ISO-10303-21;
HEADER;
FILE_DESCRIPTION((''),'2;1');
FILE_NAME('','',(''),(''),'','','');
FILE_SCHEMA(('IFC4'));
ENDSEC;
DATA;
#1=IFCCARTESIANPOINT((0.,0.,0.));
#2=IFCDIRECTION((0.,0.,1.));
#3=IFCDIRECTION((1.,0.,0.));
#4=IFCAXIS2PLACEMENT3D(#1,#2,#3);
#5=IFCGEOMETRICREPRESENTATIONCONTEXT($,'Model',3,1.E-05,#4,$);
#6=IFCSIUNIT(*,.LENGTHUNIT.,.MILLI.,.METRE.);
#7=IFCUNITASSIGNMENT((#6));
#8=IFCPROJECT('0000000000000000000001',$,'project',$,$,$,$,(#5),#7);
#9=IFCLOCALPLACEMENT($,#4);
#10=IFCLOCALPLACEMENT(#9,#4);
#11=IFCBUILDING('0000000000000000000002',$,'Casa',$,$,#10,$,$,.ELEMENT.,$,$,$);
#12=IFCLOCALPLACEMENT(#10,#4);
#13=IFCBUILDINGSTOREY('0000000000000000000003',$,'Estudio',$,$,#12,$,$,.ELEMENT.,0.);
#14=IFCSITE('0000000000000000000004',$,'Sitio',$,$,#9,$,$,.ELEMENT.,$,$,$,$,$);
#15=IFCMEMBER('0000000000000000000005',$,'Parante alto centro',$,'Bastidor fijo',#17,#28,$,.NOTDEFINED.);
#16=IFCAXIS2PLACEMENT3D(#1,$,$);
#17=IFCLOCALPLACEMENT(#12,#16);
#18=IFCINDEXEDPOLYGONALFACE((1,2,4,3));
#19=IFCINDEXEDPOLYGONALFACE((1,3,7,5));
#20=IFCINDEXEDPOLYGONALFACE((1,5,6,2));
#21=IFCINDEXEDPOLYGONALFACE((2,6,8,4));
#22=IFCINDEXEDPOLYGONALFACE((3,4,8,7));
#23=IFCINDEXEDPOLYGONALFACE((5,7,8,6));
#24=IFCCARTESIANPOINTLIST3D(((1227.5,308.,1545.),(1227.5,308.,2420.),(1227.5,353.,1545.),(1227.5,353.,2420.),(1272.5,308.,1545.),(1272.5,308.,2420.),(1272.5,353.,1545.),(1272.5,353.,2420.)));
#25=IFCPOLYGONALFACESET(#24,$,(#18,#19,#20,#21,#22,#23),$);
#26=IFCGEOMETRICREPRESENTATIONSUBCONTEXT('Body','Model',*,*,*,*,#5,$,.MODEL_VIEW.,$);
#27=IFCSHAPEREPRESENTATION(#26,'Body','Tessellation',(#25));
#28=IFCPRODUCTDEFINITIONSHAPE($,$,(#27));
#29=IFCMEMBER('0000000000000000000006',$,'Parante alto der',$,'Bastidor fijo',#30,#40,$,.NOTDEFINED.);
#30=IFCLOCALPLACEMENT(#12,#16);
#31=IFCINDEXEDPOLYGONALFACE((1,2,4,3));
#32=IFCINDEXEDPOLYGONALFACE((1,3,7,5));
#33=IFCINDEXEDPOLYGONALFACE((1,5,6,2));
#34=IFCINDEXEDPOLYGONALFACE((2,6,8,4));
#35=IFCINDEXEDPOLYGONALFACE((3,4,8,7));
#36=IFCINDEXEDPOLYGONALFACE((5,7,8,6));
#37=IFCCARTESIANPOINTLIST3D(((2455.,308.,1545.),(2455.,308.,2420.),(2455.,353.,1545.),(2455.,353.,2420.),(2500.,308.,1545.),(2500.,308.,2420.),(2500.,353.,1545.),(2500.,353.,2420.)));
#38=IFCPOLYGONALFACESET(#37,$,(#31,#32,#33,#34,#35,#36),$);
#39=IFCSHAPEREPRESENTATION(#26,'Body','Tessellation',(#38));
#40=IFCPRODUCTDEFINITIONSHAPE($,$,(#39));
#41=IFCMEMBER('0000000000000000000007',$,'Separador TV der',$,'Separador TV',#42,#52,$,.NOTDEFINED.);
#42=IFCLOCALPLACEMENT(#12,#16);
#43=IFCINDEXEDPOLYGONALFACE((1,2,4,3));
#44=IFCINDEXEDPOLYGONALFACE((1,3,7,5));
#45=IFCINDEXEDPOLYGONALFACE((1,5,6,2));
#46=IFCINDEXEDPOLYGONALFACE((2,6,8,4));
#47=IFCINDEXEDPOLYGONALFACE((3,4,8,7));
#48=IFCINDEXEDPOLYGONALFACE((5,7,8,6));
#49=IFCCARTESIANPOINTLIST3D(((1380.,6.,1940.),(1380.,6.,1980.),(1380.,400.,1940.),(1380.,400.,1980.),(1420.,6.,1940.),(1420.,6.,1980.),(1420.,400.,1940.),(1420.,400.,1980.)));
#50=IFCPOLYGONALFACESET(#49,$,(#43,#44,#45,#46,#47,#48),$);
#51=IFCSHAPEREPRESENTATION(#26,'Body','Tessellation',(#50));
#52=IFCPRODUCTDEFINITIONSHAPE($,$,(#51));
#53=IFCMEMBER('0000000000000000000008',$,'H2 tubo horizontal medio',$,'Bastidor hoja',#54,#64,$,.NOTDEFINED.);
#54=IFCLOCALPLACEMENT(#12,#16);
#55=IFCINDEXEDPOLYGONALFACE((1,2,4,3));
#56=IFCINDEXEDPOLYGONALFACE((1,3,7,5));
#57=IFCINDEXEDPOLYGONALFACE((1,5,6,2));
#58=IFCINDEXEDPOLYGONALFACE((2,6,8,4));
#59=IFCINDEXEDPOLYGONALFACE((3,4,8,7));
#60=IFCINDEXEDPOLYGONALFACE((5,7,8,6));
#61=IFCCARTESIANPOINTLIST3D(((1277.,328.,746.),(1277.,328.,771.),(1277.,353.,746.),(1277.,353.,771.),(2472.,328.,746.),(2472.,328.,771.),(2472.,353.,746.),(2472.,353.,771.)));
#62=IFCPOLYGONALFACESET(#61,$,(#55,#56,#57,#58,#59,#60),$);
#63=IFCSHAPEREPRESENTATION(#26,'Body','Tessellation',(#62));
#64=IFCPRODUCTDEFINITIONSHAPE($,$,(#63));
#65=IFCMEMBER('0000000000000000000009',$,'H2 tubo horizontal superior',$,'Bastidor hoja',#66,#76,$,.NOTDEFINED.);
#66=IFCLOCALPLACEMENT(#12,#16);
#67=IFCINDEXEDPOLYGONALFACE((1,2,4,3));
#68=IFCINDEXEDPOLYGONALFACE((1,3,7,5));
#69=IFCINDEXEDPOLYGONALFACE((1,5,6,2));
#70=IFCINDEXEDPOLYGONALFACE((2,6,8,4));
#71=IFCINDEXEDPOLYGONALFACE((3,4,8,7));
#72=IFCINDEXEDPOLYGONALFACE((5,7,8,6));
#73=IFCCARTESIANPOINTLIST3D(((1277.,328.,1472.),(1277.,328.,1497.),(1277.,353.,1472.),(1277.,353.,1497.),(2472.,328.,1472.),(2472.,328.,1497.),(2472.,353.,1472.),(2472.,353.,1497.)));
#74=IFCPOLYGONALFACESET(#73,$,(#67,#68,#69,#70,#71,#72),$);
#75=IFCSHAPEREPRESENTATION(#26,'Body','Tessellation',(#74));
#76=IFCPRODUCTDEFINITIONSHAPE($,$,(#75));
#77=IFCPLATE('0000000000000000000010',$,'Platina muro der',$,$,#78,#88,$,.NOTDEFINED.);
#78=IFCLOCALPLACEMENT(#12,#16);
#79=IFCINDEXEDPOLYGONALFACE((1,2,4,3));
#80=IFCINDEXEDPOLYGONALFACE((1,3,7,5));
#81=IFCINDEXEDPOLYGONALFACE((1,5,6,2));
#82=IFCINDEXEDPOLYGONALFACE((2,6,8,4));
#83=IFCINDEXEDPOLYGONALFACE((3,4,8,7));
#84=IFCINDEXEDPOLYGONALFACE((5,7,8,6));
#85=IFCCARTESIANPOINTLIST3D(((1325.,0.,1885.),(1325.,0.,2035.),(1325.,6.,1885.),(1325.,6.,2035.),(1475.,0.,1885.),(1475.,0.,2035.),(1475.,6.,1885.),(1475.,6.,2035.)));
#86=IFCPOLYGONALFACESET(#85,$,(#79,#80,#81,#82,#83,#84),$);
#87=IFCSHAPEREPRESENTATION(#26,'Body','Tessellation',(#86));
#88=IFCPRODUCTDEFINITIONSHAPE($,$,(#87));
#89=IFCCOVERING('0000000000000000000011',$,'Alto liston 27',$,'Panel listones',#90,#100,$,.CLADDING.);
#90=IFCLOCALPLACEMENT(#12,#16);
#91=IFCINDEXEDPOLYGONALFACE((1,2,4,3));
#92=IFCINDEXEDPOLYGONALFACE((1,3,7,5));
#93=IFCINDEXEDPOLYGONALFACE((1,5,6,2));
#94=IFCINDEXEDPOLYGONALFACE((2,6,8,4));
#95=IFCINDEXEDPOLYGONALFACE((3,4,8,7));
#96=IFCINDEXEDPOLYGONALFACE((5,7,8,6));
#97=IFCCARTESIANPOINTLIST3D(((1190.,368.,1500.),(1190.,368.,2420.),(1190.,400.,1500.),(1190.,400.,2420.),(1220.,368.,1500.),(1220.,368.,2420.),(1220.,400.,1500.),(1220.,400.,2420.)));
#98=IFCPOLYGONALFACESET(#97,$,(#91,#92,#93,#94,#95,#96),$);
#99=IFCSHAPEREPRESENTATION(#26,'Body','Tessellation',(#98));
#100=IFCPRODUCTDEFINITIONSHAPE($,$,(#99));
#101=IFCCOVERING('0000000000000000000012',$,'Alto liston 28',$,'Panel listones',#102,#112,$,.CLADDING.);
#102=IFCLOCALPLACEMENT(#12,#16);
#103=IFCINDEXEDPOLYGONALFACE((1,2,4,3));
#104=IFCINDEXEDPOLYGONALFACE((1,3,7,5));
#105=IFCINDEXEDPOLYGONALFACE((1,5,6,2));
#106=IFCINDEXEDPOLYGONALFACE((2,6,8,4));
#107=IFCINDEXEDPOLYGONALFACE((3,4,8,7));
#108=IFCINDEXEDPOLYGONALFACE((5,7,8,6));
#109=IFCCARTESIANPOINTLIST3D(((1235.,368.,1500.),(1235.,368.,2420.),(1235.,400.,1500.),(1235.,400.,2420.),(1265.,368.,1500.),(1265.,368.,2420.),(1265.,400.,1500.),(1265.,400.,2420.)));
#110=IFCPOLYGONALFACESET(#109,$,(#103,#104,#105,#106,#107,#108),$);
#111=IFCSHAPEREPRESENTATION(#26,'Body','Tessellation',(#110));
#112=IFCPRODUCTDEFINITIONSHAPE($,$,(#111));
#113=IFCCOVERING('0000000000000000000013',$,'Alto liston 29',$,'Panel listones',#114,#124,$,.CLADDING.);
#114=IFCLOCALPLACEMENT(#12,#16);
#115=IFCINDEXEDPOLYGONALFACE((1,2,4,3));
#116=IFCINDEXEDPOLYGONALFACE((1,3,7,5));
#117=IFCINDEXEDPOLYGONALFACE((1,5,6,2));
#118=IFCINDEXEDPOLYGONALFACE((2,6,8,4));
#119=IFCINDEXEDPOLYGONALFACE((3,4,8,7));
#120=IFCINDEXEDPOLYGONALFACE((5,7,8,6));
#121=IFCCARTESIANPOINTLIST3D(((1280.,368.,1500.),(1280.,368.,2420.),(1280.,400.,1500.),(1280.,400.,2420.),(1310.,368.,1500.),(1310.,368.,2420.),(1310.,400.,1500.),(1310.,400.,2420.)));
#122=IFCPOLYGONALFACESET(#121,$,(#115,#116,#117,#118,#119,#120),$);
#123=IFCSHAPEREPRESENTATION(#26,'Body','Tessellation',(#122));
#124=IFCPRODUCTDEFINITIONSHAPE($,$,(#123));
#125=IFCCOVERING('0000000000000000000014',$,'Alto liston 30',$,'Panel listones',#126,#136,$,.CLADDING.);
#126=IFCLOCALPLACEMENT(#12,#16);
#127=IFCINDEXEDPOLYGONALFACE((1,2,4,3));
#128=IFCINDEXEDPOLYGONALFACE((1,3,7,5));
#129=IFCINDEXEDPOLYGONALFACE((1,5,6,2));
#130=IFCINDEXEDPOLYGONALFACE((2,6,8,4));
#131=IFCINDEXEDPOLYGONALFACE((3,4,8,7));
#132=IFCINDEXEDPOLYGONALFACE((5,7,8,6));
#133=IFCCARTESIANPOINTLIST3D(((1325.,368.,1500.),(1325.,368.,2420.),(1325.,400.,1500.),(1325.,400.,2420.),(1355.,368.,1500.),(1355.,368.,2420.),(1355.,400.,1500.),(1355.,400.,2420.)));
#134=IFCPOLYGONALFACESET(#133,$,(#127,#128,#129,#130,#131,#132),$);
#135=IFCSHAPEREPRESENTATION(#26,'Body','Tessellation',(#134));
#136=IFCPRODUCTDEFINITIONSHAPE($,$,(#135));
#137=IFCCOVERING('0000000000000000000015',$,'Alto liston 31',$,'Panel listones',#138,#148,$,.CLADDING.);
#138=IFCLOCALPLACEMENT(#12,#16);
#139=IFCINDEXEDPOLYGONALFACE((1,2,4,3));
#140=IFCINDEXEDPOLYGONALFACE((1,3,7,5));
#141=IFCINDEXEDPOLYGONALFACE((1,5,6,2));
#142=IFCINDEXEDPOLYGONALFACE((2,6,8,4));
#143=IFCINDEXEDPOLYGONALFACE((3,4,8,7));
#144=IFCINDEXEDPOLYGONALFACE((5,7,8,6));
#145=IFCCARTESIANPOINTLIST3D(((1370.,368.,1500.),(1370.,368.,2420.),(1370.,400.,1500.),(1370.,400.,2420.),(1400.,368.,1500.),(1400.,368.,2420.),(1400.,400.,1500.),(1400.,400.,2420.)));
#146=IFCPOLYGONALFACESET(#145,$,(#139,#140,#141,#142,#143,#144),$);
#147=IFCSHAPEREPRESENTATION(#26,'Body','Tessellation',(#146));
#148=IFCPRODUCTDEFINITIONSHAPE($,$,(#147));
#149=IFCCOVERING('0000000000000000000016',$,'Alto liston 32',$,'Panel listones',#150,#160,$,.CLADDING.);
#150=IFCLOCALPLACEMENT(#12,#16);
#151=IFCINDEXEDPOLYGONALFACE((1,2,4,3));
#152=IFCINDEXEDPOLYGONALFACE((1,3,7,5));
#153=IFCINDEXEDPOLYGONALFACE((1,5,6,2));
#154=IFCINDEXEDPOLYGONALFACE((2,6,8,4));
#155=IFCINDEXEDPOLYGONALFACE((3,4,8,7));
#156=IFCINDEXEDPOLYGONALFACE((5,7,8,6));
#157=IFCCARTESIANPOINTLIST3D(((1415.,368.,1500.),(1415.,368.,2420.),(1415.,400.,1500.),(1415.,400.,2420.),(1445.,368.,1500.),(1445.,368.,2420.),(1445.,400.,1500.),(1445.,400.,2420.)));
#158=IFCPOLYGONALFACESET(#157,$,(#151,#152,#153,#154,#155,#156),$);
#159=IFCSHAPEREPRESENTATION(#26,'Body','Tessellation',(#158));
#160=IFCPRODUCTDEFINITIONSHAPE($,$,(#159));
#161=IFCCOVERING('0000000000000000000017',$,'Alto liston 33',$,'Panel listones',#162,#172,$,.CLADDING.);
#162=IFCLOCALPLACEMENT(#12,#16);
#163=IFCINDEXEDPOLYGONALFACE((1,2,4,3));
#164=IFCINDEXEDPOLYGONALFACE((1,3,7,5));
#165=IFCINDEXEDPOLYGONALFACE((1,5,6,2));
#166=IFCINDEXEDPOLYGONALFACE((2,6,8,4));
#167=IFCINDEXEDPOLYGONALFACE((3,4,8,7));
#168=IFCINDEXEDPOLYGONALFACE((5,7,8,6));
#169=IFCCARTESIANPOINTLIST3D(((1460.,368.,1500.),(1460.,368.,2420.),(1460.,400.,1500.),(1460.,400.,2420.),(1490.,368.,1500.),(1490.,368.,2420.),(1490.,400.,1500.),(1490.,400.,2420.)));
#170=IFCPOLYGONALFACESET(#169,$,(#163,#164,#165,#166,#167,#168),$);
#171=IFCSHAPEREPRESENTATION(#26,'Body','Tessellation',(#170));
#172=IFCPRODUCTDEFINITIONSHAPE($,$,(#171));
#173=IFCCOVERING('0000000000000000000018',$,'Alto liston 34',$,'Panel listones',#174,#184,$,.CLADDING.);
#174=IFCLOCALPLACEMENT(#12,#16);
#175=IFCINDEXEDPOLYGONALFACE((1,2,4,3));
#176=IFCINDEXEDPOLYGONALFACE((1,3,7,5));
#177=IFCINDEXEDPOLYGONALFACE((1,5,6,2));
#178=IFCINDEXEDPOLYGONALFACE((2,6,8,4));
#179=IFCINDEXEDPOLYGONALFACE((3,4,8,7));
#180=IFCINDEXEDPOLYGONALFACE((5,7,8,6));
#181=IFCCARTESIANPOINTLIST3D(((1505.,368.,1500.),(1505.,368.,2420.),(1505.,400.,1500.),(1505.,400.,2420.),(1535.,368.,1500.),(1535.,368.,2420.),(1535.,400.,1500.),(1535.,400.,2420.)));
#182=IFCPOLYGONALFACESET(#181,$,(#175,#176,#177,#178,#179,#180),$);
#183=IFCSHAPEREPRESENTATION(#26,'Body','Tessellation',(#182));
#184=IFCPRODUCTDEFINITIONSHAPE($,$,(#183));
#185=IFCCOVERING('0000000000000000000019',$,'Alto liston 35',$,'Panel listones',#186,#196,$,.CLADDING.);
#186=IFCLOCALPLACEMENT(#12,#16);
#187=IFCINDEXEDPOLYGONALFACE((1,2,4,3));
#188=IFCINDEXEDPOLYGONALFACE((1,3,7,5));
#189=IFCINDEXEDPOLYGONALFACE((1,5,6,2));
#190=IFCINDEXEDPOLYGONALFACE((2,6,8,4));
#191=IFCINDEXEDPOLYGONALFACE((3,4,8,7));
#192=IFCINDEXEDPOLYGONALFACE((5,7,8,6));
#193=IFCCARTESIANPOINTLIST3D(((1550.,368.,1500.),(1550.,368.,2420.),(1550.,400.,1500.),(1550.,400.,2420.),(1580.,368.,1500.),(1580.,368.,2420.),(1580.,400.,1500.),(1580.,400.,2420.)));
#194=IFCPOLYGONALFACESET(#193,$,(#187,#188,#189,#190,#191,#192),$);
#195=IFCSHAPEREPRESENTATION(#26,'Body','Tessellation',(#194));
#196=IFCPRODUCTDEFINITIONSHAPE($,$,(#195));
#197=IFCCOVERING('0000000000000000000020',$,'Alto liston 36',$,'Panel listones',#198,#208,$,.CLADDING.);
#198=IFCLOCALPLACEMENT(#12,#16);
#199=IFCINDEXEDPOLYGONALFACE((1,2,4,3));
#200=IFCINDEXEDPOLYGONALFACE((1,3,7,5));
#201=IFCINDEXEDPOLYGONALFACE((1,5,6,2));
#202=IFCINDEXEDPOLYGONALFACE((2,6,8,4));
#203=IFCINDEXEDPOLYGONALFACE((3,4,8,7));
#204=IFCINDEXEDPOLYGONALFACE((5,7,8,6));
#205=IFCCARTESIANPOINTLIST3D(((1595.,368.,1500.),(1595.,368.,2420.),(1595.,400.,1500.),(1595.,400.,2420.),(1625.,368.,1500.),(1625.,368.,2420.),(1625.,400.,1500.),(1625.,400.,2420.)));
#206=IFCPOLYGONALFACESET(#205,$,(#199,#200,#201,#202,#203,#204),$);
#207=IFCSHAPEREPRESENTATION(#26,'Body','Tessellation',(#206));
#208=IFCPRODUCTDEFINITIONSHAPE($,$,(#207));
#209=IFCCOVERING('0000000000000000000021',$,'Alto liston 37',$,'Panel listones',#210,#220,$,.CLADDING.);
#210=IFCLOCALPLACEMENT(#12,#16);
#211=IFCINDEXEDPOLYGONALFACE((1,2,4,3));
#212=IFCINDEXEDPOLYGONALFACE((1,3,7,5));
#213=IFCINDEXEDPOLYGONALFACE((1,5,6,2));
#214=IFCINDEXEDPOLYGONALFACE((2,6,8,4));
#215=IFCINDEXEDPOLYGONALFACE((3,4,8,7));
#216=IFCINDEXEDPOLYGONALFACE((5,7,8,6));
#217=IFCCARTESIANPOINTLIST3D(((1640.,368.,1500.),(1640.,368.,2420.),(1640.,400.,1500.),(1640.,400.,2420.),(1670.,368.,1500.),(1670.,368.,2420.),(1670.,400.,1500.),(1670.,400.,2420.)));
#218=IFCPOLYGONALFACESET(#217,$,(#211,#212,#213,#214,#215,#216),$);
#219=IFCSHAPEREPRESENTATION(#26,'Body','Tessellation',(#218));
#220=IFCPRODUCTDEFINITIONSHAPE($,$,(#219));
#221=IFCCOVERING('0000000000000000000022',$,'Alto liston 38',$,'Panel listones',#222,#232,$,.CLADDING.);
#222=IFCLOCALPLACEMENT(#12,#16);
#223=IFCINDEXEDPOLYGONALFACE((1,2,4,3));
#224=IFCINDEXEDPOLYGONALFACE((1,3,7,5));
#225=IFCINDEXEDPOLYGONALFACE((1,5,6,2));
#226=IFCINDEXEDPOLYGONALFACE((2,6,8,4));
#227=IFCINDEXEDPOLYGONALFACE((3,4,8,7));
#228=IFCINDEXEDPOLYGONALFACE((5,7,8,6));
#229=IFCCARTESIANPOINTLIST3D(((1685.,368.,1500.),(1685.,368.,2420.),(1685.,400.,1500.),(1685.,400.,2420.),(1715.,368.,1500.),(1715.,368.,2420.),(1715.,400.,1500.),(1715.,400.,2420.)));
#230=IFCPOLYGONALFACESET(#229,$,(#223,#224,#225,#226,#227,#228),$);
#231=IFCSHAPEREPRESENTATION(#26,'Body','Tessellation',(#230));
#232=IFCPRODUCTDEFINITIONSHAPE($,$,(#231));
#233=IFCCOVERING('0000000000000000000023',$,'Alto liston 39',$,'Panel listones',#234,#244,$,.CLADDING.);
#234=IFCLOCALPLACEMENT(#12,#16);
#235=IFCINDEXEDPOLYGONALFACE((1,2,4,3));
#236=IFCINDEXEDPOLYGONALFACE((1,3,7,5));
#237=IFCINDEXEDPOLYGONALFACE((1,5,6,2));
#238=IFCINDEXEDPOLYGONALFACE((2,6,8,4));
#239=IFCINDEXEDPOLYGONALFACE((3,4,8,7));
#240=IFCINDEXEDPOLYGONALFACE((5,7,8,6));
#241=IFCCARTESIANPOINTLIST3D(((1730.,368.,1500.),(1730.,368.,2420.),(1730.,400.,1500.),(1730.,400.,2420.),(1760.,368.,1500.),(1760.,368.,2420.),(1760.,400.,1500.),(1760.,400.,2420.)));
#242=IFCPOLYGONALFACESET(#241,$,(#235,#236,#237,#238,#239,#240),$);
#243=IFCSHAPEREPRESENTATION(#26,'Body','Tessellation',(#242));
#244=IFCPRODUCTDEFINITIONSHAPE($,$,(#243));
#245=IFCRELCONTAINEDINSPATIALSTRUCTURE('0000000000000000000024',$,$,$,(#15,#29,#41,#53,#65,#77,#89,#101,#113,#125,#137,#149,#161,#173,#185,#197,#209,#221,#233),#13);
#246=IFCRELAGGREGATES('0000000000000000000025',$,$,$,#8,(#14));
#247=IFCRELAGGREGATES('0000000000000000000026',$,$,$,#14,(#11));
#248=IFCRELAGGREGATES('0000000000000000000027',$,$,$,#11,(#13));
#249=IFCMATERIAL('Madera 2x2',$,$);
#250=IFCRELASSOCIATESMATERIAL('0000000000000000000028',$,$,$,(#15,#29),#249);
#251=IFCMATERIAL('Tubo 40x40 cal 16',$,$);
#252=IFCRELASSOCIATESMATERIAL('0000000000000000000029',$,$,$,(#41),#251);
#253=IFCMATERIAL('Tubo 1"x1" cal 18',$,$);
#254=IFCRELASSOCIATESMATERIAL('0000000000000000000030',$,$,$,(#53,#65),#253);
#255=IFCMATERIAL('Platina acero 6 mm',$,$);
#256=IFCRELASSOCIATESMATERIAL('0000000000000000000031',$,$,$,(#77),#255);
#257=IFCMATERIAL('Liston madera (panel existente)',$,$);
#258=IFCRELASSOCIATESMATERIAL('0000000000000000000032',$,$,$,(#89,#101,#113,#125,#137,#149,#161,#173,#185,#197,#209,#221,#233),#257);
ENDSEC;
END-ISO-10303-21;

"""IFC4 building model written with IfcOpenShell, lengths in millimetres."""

from ifc_helpers import new_model, si_unit, frame, frame_2d, origin_with_axes, place, context, subcontext, project, spatial, rectangle, extrude, material, element, save


model = new_model("IFC4")

# Units and contexts
model_context = context("Model", 3, precision=1e-05, world=origin_with_axes())
body_context = subcontext(model_context, "Body", "Model", "MODEL_VIEW")
ifc_project = project(units=[si_unit("LENGTHUNIT", "METRE", prefix="MILLI")], contexts=[model_context])

# Site, building, storey
site_placement = place(None, origin_with_axes())
site = spatial("IfcSite", under=ifc_project, at=site_placement, Name="Sitio", CompositionType="ELEMENT")
building_placement = place(site_placement, origin_with_axes())
building = spatial("IfcBuilding", under=site, at=building_placement, Name="Casa", CompositionType="ELEMENT")
storey_placement = place(building_placement, origin_with_axes())
storey = spatial("IfcBuildingStorey", under=building, at=storey_placement, Name="Estudio", CompositionType="ELEMENT", Elevation=0.0)

# Members
ifc_material_1 = material(Name="Madera 2x2")
for number, where, z_axis, x_axis, name in (
    (1, (1227.5, 308.0, 1545.0), (0.0, 0.0, 1.0), (1.0, 0.0, 0.0), "Parante alto centro"),
    (2, (2455.0, 308.0, 1545.0), (0.0, 0.0, 1.0), (1.0, 0.0, 0.0), "Parante alto der"),
):
    element("IfcMember", number, at=place(storey_placement, frame(where, z_axis=z_axis, x_axis=x_axis)), inside=storey, material=ifc_material_1, Name=name, ObjectType="Bastidor fijo", PredefinedType="NOTDEFINED", context=body_context, shape_type="SweptSolid", body=[
        extrude(rectangle(XDim=45.0, YDim=45.0, at=frame_2d((22.5, 22.5))), origin_with_axes(), (0.0, 0.0, 1.0), 875.0),
    ])
ifc_material_2 = material(Name="Tubo 40x40 cal 16")
member_placement = place(storey_placement, frame((1380.0, 6.0, 1940.0), z_axis=(0.0, 0.0, 1.0), x_axis=(1.0, 0.0, 0.0)))
element("IfcMember", 3, at=member_placement, inside=storey, material=ifc_material_2, Name="Separador TV der", ObjectType="Separador TV", PredefinedType="NOTDEFINED", context=body_context, shape_type="SweptSolid", body=[
    extrude(rectangle(XDim=40.0, YDim=394.0, at=frame_2d((20.0, 197.0))), origin_with_axes(), (0.0, 0.0, 1.0), 40.0),
])
ifc_material_3 = material(Name="Tubo 1\"x1\" cal 18")
for number, where, z_axis, x_axis, name in (
    (4, (1277.0, 328.0, 746.0), (0.0, 0.0, 1.0), (1.0, 0.0, 0.0), "H2 tubo horizontal medio"),
    (5, (1277.0, 328.0, 1472.0), (0.0, 0.0, 1.0), (1.0, 0.0, 0.0), "H2 tubo horizontal superior"),
):
    element("IfcMember", number, at=place(storey_placement, frame(where, z_axis=z_axis, x_axis=x_axis)), inside=storey, material=ifc_material_3, Name=name, ObjectType="Bastidor hoja", PredefinedType="NOTDEFINED", context=body_context, shape_type="SweptSolid", body=[
        extrude(rectangle(XDim=1195.0, YDim=25.0, at=frame_2d((597.5, 12.5))), origin_with_axes(), (0.0, 0.0, 1.0), 25.0),
    ])

# Plate
ifc_material_4 = material(Name="Platina acero 6 mm")
plate_placement = place(storey_placement, frame((1325.0, 0.0, 1885.0), z_axis=(0.0, 0.0, 1.0), x_axis=(1.0, 0.0, 0.0)))
element("IfcPlate", 6, at=plate_placement, inside=storey, material=ifc_material_4, Name="Platina muro der", PredefinedType="NOTDEFINED", context=body_context, shape_type="SweptSolid", body=[
    extrude(rectangle(XDim=150.0, YDim=6.0, at=frame_2d((75.0, 3.0))), origin_with_axes(), (0.0, 0.0, 1.0), 150.0),
])

# Coverings
ifc_material_5 = material(Name="Liston madera (panel existente)")
for number, where, z_axis, x_axis, name in (
    (7, (1190.0, 368.0, 1500.0), (0.0, 0.0, 1.0), (1.0, 0.0, 0.0), "Alto liston 27"),
    (8, (1235.0, 368.0, 1500.0), (0.0, 0.0, 1.0), (1.0, 0.0, 0.0), "Alto liston 28"),
    (9, (1280.0, 368.0, 1500.0), (0.0, 0.0, 1.0), (1.0, 0.0, 0.0), "Alto liston 29"),
    (10, (1325.0, 368.0, 1500.0), (0.0, 0.0, 1.0), (1.0, 0.0, 0.0), "Alto liston 30"),
    (11, (1370.0, 368.0, 1500.0), (0.0, 0.0, 1.0), (1.0, 0.0, 0.0), "Alto liston 31"),
    (12, (1415.0, 368.0, 1500.0), (0.0, 0.0, 1.0), (1.0, 0.0, 0.0), "Alto liston 32"),
    (13, (1460.0, 368.0, 1500.0), (0.0, 0.0, 1.0), (1.0, 0.0, 0.0), "Alto liston 33"),
    (14, (1505.0, 368.0, 1500.0), (0.0, 0.0, 1.0), (1.0, 0.0, 0.0), "Alto liston 34"),
    (15, (1550.0, 368.0, 1500.0), (0.0, 0.0, 1.0), (1.0, 0.0, 0.0), "Alto liston 35"),
    (16, (1595.0, 368.0, 1500.0), (0.0, 0.0, 1.0), (1.0, 0.0, 0.0), "Alto liston 36"),
    (17, (1640.0, 368.0, 1500.0), (0.0, 0.0, 1.0), (1.0, 0.0, 0.0), "Alto liston 37"),
    (18, (1685.0, 368.0, 1500.0), (0.0, 0.0, 1.0), (1.0, 0.0, 0.0), "Alto liston 38"),
    (19, (1730.0, 368.0, 1500.0), (0.0, 0.0, 1.0), (1.0, 0.0, 0.0), "Alto liston 39"),
):
    element("IfcCovering", number, at=place(storey_placement, frame(where, z_axis=z_axis, x_axis=x_axis)), inside=storey, material=ifc_material_5, Name=name, ObjectType="Panel listones", PredefinedType="CLADDING", context=body_context, shape_type="SweptSolid", body=[
        extrude(rectangle(XDim=30.0, YDim=32.0, at=frame_2d((15.0, 16.0))), origin_with_axes(), (0.0, 0.0, 1.0), 920.0),
    ])

save(model, "model.ifc")
